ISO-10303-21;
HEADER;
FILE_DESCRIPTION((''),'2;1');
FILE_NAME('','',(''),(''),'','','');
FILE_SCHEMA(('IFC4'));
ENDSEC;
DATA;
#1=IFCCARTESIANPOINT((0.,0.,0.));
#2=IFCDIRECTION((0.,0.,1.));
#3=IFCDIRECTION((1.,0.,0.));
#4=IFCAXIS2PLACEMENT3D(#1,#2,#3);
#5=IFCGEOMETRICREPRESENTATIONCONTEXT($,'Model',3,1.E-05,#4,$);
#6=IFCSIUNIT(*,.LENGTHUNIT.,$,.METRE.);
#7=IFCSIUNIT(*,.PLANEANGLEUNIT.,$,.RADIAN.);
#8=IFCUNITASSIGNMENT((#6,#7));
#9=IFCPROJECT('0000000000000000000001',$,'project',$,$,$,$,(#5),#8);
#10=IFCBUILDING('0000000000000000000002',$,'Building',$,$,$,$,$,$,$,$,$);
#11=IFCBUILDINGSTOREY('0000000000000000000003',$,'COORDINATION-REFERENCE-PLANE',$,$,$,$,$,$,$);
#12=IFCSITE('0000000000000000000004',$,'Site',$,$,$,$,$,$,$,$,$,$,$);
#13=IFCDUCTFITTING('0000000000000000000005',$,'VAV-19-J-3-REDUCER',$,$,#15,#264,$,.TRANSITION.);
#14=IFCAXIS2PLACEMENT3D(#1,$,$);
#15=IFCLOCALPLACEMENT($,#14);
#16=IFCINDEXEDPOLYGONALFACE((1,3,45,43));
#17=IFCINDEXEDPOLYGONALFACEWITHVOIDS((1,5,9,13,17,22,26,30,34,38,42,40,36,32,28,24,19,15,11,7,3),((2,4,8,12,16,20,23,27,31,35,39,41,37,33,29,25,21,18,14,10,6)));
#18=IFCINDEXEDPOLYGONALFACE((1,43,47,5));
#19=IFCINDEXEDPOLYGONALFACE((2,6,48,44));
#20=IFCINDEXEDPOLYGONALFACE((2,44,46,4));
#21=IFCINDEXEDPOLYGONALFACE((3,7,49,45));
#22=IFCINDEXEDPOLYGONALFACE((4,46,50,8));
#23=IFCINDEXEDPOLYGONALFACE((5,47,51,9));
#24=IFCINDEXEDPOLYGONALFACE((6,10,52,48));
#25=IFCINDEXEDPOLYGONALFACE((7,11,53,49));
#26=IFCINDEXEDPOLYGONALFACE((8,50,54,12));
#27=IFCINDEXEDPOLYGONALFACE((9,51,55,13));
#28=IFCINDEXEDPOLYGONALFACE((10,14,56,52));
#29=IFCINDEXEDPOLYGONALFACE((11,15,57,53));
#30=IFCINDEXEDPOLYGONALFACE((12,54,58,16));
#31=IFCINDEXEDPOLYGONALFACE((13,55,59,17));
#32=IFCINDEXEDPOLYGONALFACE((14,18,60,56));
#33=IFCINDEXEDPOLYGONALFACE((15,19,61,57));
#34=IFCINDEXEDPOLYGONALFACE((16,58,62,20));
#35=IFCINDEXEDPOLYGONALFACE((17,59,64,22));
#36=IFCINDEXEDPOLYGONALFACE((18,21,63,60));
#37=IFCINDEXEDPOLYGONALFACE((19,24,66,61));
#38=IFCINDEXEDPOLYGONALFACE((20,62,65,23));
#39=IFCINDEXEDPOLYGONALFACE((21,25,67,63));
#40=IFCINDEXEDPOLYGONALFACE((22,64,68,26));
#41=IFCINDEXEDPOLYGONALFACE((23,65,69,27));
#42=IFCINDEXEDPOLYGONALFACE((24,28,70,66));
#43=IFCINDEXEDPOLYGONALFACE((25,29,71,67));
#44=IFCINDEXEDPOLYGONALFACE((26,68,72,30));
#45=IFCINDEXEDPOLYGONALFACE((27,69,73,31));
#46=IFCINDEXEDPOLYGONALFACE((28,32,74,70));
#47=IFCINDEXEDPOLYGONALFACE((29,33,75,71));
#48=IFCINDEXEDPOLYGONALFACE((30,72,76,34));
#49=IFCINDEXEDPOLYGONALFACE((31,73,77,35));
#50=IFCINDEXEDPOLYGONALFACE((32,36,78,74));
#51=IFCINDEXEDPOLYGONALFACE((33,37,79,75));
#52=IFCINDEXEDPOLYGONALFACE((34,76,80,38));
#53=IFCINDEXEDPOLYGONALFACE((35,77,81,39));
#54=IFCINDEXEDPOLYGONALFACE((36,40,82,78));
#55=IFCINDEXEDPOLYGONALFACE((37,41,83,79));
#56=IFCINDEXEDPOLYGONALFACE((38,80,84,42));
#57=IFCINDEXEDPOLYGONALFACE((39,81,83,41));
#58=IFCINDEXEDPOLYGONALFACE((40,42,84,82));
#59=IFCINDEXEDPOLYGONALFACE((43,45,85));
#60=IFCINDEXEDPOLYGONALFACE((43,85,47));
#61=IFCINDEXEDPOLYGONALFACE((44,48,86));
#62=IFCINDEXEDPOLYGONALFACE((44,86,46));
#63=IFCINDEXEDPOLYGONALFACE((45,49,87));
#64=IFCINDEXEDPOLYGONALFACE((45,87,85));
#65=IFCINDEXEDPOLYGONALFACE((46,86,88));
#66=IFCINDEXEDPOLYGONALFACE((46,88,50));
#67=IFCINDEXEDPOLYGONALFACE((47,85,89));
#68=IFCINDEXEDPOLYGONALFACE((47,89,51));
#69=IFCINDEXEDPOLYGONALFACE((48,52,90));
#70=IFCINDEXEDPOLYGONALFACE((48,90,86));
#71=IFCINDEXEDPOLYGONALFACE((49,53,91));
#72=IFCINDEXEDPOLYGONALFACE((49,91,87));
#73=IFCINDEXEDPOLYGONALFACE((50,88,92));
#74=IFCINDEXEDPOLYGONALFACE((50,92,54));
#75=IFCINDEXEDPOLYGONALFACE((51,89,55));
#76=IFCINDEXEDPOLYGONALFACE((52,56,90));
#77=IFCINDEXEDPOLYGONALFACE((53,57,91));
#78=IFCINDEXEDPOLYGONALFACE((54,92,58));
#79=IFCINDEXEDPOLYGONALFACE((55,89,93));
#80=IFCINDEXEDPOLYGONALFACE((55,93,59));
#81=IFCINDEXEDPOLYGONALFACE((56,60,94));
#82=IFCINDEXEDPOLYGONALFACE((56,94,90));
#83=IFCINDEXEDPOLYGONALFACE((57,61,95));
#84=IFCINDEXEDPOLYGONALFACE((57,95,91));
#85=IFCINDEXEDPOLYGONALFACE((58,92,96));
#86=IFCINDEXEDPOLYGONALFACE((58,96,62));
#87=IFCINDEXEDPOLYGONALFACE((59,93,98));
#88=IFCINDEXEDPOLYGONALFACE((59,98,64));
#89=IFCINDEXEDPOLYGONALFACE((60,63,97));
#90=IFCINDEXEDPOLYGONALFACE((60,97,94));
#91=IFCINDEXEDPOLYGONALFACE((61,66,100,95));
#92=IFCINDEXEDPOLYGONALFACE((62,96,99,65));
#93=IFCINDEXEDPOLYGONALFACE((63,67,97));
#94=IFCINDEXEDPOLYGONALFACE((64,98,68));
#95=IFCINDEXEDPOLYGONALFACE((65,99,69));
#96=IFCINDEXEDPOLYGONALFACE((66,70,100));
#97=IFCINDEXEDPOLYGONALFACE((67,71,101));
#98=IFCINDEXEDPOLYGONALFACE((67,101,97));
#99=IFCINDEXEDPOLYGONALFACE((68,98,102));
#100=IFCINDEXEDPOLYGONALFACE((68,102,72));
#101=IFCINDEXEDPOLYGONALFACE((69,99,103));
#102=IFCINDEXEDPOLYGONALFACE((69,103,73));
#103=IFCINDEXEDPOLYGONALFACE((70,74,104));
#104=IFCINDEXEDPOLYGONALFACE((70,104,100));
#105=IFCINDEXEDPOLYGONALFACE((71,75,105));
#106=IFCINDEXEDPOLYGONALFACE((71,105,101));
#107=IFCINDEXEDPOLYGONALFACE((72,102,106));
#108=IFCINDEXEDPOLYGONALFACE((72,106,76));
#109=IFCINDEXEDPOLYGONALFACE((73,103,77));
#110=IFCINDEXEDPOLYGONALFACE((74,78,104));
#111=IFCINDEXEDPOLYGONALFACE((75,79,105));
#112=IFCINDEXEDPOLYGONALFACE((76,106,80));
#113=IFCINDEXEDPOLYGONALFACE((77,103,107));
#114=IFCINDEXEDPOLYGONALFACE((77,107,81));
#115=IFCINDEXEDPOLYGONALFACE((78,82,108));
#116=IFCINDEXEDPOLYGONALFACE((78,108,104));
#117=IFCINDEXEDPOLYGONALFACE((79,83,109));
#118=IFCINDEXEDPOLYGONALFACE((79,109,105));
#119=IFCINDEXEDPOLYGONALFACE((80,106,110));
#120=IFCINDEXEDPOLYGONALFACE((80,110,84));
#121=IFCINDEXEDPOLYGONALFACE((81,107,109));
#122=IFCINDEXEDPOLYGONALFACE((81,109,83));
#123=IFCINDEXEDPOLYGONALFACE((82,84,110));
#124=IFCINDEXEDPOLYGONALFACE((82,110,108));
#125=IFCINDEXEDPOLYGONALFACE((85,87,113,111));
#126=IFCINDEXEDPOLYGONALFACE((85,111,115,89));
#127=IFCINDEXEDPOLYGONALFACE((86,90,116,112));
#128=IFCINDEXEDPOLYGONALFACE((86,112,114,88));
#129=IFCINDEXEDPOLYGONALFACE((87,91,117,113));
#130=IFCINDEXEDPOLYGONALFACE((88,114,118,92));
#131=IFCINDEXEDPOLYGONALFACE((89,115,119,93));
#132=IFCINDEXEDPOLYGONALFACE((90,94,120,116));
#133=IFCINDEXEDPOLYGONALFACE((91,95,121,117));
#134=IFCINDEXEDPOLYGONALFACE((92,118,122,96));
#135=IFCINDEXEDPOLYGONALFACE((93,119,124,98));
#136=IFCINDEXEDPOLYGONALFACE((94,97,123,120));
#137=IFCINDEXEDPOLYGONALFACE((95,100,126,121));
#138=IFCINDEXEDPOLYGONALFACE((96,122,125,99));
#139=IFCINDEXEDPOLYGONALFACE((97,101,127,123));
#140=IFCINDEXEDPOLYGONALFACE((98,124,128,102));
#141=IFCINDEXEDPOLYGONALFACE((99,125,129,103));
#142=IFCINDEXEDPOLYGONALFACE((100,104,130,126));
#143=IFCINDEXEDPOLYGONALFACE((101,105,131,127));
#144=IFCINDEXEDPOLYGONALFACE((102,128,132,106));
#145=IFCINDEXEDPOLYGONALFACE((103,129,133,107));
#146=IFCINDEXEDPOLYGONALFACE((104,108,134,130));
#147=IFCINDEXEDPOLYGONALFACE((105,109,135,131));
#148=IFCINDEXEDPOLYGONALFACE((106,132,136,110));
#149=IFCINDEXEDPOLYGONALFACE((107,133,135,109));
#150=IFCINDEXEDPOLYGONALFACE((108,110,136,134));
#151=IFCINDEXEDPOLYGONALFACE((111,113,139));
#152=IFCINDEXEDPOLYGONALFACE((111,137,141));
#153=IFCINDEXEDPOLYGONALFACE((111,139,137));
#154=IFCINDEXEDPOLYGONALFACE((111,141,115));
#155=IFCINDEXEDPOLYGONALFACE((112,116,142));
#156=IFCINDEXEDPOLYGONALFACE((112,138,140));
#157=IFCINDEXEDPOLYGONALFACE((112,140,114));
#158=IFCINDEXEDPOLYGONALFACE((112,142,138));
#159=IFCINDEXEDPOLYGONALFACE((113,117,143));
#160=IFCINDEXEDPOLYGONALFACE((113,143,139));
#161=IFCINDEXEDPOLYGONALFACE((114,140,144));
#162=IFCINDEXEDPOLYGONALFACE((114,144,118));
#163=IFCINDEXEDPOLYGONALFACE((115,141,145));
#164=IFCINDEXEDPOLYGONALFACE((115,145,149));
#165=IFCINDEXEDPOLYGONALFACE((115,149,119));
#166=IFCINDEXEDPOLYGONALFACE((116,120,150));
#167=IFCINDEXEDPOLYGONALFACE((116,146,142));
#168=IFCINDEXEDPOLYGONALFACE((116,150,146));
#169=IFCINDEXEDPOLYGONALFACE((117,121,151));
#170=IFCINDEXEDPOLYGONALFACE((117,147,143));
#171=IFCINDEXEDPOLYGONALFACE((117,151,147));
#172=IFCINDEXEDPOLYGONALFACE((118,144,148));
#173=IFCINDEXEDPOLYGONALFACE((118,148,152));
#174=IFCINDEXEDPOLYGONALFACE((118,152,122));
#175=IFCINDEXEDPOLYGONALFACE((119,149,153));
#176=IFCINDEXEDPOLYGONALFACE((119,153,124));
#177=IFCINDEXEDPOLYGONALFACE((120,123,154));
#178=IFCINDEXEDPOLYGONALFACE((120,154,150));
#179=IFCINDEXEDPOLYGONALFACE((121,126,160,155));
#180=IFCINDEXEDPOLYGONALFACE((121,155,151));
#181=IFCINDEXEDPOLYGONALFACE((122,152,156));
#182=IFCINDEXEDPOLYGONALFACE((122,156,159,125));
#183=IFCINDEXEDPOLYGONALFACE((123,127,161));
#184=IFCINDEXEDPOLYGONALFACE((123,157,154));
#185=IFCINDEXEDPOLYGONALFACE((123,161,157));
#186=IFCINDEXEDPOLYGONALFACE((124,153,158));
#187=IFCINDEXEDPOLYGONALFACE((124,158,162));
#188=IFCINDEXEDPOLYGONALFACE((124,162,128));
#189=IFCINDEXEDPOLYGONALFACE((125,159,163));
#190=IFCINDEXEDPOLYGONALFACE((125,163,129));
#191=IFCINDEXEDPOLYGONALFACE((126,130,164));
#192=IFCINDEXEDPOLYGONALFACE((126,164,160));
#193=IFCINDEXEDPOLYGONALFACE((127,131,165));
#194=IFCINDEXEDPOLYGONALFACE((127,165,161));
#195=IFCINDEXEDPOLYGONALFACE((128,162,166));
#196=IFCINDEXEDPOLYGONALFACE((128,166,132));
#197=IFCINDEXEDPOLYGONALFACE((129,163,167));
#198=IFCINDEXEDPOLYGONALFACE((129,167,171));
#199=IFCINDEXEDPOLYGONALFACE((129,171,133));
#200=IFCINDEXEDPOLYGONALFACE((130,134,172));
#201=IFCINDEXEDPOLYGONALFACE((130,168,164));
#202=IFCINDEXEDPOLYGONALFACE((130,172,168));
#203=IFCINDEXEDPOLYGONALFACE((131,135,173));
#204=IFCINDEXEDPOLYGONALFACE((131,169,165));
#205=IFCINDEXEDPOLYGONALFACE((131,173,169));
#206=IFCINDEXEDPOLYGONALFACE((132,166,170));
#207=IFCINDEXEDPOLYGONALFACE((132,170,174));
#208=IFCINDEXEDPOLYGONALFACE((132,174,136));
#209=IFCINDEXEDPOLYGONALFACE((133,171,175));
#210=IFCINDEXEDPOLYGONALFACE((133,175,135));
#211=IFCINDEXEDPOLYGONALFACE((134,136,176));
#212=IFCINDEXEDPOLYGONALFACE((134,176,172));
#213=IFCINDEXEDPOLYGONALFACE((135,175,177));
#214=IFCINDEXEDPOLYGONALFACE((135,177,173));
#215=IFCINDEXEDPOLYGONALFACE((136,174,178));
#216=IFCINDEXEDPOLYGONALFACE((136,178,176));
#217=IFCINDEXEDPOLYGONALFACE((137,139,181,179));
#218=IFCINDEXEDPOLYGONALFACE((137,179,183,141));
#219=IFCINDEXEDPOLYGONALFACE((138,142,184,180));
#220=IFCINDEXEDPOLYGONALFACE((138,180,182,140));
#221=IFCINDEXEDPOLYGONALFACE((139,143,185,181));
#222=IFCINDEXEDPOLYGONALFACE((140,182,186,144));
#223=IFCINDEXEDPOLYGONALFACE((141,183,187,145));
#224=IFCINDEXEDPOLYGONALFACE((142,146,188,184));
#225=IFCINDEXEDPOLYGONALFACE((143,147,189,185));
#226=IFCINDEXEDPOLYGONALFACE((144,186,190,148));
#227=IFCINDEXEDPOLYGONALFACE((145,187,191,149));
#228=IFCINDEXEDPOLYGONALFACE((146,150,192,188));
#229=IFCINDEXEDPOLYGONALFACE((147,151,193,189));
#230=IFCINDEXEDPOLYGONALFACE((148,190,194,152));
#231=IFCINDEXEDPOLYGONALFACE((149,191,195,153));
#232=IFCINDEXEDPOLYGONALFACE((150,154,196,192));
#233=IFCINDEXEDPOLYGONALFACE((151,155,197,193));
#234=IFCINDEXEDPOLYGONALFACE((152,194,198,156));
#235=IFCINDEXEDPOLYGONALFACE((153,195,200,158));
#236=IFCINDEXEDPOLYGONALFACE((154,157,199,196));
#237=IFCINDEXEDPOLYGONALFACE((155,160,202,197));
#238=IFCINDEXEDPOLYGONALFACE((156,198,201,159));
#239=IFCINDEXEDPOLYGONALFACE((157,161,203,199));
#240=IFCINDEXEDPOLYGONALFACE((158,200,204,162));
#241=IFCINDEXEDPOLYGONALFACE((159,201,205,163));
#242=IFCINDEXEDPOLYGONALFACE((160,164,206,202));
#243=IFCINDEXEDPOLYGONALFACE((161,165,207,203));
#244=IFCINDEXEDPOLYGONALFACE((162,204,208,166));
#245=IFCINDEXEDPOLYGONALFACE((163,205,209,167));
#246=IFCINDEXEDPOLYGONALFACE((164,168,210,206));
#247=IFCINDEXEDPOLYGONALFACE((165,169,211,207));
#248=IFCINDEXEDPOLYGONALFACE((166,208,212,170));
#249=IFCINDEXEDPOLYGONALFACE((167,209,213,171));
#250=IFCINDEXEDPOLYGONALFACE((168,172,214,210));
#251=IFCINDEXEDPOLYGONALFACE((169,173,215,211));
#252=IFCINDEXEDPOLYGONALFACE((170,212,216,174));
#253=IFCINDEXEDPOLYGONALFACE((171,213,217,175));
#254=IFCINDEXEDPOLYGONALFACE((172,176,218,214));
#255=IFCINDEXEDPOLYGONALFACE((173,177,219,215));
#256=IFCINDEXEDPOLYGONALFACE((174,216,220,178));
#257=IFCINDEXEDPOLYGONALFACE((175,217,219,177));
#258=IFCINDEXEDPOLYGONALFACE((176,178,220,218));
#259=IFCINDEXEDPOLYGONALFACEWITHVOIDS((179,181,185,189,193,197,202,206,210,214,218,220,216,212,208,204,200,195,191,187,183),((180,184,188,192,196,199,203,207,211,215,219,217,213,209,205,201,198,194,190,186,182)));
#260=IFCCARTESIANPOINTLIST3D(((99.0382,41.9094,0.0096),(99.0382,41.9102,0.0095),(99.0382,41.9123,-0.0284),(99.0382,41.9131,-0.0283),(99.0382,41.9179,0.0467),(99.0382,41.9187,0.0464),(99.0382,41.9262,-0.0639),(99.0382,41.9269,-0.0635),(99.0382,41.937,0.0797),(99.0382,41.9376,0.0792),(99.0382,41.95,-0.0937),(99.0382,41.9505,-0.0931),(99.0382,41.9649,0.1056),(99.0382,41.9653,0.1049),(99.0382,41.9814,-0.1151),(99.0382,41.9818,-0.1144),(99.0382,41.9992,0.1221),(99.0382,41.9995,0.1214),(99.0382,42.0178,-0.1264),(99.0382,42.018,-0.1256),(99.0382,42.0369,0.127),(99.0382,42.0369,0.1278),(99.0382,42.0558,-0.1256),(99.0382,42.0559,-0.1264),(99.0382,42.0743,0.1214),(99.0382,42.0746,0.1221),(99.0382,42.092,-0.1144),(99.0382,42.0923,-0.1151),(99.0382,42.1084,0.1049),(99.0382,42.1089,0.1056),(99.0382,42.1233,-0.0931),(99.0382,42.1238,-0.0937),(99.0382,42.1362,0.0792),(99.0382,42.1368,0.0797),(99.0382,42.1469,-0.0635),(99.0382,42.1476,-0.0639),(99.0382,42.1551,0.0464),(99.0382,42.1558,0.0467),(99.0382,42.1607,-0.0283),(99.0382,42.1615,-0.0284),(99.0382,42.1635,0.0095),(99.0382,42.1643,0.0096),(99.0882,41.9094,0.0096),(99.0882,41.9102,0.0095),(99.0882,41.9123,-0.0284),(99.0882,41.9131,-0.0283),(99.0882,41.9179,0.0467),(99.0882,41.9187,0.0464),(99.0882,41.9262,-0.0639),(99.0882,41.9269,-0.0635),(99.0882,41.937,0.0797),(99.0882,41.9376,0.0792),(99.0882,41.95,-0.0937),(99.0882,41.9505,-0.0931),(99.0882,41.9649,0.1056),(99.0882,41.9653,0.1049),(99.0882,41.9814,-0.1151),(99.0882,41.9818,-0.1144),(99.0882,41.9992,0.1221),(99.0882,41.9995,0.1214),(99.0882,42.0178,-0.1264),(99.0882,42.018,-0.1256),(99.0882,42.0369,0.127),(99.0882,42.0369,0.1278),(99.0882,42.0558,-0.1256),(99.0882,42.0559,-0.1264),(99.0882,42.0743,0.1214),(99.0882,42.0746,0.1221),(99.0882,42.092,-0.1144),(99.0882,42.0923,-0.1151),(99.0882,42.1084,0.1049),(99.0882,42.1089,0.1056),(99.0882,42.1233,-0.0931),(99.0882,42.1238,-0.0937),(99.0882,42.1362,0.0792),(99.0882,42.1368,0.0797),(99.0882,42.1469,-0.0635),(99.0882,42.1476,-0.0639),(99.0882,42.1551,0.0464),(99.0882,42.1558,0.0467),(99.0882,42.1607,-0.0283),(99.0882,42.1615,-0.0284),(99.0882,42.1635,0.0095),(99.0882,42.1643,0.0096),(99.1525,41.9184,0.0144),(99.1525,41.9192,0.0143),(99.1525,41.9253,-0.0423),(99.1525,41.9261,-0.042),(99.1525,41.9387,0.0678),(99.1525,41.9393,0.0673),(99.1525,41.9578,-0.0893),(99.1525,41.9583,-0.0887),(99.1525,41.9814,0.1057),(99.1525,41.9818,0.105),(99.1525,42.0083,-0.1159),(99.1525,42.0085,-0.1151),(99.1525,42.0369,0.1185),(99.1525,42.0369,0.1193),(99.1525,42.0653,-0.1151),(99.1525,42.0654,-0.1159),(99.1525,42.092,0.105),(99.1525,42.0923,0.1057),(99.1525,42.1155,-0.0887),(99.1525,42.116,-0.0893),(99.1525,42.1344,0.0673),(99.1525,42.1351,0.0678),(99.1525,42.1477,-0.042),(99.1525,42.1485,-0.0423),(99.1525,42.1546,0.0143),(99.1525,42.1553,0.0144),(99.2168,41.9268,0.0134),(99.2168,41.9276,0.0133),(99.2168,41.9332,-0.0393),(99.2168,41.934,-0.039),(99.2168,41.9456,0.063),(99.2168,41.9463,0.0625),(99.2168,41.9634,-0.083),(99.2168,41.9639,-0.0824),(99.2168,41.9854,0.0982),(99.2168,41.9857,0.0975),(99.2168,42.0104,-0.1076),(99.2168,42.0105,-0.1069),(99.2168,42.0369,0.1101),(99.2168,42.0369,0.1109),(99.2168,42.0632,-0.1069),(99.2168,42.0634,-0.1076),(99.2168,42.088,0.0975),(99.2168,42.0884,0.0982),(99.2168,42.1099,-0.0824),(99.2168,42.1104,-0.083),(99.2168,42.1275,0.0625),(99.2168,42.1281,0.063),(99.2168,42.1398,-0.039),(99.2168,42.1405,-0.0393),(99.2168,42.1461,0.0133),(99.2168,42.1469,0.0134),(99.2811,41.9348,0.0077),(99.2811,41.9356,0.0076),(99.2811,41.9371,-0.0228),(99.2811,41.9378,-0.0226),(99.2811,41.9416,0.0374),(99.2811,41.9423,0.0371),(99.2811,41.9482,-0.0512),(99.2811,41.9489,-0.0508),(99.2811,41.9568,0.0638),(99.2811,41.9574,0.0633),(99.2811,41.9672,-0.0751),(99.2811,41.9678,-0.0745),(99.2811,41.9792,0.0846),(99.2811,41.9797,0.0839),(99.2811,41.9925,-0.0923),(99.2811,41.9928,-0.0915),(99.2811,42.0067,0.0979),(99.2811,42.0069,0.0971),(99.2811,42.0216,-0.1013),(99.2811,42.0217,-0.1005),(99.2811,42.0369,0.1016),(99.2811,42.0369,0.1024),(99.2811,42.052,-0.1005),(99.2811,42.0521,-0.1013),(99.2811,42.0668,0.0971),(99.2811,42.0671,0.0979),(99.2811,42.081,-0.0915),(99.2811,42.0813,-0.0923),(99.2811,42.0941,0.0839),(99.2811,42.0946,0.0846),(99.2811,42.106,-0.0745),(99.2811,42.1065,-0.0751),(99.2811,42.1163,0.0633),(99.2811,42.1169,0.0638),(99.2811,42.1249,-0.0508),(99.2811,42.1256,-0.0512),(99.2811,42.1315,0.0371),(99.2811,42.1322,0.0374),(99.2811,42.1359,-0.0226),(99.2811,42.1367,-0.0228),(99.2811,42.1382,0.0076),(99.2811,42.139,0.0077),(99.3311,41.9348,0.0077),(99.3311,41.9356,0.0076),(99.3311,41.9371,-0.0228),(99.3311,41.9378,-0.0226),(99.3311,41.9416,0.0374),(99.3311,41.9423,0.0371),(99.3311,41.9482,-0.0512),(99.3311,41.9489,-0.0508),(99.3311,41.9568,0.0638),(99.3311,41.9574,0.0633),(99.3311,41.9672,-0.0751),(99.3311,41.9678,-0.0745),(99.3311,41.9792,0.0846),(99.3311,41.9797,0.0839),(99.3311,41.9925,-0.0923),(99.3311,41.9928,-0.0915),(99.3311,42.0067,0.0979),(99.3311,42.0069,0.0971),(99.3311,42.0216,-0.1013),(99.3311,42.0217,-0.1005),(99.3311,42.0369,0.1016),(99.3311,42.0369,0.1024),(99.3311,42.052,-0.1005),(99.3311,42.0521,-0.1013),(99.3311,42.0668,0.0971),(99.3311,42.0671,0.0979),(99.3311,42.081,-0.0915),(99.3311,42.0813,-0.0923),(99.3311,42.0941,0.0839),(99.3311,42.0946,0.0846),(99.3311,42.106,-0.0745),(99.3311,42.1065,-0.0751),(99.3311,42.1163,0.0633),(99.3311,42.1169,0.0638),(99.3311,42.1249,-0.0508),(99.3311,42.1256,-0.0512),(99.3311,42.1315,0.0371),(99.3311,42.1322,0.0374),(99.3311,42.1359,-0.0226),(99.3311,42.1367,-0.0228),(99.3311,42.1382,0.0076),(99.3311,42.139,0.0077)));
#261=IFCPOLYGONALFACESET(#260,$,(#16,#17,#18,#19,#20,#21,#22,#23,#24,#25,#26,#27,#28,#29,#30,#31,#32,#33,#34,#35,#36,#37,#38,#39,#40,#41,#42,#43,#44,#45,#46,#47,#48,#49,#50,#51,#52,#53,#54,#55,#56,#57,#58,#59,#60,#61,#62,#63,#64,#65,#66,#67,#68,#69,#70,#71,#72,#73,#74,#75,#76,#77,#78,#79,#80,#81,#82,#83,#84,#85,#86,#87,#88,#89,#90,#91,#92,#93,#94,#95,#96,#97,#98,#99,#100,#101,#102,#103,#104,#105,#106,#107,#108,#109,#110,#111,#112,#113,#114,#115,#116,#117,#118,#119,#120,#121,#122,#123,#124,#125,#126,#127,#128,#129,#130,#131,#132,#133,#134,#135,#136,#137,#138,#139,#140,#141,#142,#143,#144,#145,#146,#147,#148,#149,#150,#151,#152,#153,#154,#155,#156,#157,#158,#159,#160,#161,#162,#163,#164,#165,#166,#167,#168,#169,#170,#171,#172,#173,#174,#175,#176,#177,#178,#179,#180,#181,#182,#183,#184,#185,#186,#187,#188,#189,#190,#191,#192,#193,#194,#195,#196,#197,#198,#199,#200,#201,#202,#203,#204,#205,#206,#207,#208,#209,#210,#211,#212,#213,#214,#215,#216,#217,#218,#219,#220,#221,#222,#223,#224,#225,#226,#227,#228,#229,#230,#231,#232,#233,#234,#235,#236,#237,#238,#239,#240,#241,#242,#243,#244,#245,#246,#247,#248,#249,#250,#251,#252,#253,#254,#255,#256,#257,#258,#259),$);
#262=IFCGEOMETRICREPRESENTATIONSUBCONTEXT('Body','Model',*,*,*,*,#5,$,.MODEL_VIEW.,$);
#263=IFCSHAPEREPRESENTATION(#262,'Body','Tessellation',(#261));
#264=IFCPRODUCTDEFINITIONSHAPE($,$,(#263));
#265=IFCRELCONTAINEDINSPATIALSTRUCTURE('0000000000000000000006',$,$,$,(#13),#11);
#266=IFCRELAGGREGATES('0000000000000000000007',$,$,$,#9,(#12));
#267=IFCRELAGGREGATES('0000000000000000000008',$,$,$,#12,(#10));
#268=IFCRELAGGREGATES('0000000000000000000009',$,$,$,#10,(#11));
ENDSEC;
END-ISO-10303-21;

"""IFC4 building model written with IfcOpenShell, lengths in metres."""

from ifc_helpers import new_model, entity, si_unit, frame, origin_with_axes, place, context, subcontext, project, spatial, element, save


model = new_model("IFC4")

# Units and contexts
model_context_1 = context("Model", 3, precision=1e-05, world=origin_with_axes())
body_context_1 = subcontext(model_context_1, "Body", "Model", "MODEL_VIEW")
ifc_project = project(units=[si_unit("LENGTHUNIT", "METRE"), si_unit("PLANEANGLEUNIT", "RADIAN")], contexts=[model_context_1])

# Site, building, storey
site = spatial("IfcSite", under=ifc_project, Name="Site")
building = spatial("IfcBuilding", under=site, Name="Building")
storey = spatial("IfcBuildingStorey", under=building, Name="COORDINATION-REFERENCE-PLANE")

# Duct fitting
for number, where, z_axis, x_axis, name in (
    (1, (99.0382, 42.0369, 0.0), (0.0, 1.0, 0.0), (0.0, 0.0, 1.0), "VAV-19-J-3-REDUCER"),
):
    element("IfcDuctFitting", number, at=place(None, frame(where, z_axis=z_axis, x_axis=x_axis)), inside=storey, Name=name, PredefinedType="TRANSITION", context=body_context_1, shape_type="SweptSolid", body=[
        entity("IfcRevolvedAreaSolid", entity("IfcArbitraryClosedProfileDef", "AREA", None, entity("IfcPolyline", [entity("IfcCartesianPoint", [0.1278, 0.0]), entity("IfcCartesianPoint", [0.1278, 0.05]), entity("IfcCartesianPoint", [0.1024, 0.2429]), entity("IfcCartesianPoint", [0.1024, 0.2929]), entity("IfcCartesianPoint", [0.1016, 0.2929]), entity("IfcCartesianPoint", [0.1016, 0.2429]), entity("IfcCartesianPoint", [0.127, 0.05]), entity("IfcCartesianPoint", [0.127, 0.0]), entity("IfcCartesianPoint", [0.1278, 0.0])])), entity("IfcAxis2Placement3D", entity("IfcCartesianPoint", [0.0, 0.0, 0.0])), entity("IfcAxis1Placement", entity("IfcCartesianPoint", [0.0, 0.0, 0.0]), entity("IfcDirection", [0.0, 1.0, 0.0])), 6.283185),
    ])

save(model, "model.ifc")
